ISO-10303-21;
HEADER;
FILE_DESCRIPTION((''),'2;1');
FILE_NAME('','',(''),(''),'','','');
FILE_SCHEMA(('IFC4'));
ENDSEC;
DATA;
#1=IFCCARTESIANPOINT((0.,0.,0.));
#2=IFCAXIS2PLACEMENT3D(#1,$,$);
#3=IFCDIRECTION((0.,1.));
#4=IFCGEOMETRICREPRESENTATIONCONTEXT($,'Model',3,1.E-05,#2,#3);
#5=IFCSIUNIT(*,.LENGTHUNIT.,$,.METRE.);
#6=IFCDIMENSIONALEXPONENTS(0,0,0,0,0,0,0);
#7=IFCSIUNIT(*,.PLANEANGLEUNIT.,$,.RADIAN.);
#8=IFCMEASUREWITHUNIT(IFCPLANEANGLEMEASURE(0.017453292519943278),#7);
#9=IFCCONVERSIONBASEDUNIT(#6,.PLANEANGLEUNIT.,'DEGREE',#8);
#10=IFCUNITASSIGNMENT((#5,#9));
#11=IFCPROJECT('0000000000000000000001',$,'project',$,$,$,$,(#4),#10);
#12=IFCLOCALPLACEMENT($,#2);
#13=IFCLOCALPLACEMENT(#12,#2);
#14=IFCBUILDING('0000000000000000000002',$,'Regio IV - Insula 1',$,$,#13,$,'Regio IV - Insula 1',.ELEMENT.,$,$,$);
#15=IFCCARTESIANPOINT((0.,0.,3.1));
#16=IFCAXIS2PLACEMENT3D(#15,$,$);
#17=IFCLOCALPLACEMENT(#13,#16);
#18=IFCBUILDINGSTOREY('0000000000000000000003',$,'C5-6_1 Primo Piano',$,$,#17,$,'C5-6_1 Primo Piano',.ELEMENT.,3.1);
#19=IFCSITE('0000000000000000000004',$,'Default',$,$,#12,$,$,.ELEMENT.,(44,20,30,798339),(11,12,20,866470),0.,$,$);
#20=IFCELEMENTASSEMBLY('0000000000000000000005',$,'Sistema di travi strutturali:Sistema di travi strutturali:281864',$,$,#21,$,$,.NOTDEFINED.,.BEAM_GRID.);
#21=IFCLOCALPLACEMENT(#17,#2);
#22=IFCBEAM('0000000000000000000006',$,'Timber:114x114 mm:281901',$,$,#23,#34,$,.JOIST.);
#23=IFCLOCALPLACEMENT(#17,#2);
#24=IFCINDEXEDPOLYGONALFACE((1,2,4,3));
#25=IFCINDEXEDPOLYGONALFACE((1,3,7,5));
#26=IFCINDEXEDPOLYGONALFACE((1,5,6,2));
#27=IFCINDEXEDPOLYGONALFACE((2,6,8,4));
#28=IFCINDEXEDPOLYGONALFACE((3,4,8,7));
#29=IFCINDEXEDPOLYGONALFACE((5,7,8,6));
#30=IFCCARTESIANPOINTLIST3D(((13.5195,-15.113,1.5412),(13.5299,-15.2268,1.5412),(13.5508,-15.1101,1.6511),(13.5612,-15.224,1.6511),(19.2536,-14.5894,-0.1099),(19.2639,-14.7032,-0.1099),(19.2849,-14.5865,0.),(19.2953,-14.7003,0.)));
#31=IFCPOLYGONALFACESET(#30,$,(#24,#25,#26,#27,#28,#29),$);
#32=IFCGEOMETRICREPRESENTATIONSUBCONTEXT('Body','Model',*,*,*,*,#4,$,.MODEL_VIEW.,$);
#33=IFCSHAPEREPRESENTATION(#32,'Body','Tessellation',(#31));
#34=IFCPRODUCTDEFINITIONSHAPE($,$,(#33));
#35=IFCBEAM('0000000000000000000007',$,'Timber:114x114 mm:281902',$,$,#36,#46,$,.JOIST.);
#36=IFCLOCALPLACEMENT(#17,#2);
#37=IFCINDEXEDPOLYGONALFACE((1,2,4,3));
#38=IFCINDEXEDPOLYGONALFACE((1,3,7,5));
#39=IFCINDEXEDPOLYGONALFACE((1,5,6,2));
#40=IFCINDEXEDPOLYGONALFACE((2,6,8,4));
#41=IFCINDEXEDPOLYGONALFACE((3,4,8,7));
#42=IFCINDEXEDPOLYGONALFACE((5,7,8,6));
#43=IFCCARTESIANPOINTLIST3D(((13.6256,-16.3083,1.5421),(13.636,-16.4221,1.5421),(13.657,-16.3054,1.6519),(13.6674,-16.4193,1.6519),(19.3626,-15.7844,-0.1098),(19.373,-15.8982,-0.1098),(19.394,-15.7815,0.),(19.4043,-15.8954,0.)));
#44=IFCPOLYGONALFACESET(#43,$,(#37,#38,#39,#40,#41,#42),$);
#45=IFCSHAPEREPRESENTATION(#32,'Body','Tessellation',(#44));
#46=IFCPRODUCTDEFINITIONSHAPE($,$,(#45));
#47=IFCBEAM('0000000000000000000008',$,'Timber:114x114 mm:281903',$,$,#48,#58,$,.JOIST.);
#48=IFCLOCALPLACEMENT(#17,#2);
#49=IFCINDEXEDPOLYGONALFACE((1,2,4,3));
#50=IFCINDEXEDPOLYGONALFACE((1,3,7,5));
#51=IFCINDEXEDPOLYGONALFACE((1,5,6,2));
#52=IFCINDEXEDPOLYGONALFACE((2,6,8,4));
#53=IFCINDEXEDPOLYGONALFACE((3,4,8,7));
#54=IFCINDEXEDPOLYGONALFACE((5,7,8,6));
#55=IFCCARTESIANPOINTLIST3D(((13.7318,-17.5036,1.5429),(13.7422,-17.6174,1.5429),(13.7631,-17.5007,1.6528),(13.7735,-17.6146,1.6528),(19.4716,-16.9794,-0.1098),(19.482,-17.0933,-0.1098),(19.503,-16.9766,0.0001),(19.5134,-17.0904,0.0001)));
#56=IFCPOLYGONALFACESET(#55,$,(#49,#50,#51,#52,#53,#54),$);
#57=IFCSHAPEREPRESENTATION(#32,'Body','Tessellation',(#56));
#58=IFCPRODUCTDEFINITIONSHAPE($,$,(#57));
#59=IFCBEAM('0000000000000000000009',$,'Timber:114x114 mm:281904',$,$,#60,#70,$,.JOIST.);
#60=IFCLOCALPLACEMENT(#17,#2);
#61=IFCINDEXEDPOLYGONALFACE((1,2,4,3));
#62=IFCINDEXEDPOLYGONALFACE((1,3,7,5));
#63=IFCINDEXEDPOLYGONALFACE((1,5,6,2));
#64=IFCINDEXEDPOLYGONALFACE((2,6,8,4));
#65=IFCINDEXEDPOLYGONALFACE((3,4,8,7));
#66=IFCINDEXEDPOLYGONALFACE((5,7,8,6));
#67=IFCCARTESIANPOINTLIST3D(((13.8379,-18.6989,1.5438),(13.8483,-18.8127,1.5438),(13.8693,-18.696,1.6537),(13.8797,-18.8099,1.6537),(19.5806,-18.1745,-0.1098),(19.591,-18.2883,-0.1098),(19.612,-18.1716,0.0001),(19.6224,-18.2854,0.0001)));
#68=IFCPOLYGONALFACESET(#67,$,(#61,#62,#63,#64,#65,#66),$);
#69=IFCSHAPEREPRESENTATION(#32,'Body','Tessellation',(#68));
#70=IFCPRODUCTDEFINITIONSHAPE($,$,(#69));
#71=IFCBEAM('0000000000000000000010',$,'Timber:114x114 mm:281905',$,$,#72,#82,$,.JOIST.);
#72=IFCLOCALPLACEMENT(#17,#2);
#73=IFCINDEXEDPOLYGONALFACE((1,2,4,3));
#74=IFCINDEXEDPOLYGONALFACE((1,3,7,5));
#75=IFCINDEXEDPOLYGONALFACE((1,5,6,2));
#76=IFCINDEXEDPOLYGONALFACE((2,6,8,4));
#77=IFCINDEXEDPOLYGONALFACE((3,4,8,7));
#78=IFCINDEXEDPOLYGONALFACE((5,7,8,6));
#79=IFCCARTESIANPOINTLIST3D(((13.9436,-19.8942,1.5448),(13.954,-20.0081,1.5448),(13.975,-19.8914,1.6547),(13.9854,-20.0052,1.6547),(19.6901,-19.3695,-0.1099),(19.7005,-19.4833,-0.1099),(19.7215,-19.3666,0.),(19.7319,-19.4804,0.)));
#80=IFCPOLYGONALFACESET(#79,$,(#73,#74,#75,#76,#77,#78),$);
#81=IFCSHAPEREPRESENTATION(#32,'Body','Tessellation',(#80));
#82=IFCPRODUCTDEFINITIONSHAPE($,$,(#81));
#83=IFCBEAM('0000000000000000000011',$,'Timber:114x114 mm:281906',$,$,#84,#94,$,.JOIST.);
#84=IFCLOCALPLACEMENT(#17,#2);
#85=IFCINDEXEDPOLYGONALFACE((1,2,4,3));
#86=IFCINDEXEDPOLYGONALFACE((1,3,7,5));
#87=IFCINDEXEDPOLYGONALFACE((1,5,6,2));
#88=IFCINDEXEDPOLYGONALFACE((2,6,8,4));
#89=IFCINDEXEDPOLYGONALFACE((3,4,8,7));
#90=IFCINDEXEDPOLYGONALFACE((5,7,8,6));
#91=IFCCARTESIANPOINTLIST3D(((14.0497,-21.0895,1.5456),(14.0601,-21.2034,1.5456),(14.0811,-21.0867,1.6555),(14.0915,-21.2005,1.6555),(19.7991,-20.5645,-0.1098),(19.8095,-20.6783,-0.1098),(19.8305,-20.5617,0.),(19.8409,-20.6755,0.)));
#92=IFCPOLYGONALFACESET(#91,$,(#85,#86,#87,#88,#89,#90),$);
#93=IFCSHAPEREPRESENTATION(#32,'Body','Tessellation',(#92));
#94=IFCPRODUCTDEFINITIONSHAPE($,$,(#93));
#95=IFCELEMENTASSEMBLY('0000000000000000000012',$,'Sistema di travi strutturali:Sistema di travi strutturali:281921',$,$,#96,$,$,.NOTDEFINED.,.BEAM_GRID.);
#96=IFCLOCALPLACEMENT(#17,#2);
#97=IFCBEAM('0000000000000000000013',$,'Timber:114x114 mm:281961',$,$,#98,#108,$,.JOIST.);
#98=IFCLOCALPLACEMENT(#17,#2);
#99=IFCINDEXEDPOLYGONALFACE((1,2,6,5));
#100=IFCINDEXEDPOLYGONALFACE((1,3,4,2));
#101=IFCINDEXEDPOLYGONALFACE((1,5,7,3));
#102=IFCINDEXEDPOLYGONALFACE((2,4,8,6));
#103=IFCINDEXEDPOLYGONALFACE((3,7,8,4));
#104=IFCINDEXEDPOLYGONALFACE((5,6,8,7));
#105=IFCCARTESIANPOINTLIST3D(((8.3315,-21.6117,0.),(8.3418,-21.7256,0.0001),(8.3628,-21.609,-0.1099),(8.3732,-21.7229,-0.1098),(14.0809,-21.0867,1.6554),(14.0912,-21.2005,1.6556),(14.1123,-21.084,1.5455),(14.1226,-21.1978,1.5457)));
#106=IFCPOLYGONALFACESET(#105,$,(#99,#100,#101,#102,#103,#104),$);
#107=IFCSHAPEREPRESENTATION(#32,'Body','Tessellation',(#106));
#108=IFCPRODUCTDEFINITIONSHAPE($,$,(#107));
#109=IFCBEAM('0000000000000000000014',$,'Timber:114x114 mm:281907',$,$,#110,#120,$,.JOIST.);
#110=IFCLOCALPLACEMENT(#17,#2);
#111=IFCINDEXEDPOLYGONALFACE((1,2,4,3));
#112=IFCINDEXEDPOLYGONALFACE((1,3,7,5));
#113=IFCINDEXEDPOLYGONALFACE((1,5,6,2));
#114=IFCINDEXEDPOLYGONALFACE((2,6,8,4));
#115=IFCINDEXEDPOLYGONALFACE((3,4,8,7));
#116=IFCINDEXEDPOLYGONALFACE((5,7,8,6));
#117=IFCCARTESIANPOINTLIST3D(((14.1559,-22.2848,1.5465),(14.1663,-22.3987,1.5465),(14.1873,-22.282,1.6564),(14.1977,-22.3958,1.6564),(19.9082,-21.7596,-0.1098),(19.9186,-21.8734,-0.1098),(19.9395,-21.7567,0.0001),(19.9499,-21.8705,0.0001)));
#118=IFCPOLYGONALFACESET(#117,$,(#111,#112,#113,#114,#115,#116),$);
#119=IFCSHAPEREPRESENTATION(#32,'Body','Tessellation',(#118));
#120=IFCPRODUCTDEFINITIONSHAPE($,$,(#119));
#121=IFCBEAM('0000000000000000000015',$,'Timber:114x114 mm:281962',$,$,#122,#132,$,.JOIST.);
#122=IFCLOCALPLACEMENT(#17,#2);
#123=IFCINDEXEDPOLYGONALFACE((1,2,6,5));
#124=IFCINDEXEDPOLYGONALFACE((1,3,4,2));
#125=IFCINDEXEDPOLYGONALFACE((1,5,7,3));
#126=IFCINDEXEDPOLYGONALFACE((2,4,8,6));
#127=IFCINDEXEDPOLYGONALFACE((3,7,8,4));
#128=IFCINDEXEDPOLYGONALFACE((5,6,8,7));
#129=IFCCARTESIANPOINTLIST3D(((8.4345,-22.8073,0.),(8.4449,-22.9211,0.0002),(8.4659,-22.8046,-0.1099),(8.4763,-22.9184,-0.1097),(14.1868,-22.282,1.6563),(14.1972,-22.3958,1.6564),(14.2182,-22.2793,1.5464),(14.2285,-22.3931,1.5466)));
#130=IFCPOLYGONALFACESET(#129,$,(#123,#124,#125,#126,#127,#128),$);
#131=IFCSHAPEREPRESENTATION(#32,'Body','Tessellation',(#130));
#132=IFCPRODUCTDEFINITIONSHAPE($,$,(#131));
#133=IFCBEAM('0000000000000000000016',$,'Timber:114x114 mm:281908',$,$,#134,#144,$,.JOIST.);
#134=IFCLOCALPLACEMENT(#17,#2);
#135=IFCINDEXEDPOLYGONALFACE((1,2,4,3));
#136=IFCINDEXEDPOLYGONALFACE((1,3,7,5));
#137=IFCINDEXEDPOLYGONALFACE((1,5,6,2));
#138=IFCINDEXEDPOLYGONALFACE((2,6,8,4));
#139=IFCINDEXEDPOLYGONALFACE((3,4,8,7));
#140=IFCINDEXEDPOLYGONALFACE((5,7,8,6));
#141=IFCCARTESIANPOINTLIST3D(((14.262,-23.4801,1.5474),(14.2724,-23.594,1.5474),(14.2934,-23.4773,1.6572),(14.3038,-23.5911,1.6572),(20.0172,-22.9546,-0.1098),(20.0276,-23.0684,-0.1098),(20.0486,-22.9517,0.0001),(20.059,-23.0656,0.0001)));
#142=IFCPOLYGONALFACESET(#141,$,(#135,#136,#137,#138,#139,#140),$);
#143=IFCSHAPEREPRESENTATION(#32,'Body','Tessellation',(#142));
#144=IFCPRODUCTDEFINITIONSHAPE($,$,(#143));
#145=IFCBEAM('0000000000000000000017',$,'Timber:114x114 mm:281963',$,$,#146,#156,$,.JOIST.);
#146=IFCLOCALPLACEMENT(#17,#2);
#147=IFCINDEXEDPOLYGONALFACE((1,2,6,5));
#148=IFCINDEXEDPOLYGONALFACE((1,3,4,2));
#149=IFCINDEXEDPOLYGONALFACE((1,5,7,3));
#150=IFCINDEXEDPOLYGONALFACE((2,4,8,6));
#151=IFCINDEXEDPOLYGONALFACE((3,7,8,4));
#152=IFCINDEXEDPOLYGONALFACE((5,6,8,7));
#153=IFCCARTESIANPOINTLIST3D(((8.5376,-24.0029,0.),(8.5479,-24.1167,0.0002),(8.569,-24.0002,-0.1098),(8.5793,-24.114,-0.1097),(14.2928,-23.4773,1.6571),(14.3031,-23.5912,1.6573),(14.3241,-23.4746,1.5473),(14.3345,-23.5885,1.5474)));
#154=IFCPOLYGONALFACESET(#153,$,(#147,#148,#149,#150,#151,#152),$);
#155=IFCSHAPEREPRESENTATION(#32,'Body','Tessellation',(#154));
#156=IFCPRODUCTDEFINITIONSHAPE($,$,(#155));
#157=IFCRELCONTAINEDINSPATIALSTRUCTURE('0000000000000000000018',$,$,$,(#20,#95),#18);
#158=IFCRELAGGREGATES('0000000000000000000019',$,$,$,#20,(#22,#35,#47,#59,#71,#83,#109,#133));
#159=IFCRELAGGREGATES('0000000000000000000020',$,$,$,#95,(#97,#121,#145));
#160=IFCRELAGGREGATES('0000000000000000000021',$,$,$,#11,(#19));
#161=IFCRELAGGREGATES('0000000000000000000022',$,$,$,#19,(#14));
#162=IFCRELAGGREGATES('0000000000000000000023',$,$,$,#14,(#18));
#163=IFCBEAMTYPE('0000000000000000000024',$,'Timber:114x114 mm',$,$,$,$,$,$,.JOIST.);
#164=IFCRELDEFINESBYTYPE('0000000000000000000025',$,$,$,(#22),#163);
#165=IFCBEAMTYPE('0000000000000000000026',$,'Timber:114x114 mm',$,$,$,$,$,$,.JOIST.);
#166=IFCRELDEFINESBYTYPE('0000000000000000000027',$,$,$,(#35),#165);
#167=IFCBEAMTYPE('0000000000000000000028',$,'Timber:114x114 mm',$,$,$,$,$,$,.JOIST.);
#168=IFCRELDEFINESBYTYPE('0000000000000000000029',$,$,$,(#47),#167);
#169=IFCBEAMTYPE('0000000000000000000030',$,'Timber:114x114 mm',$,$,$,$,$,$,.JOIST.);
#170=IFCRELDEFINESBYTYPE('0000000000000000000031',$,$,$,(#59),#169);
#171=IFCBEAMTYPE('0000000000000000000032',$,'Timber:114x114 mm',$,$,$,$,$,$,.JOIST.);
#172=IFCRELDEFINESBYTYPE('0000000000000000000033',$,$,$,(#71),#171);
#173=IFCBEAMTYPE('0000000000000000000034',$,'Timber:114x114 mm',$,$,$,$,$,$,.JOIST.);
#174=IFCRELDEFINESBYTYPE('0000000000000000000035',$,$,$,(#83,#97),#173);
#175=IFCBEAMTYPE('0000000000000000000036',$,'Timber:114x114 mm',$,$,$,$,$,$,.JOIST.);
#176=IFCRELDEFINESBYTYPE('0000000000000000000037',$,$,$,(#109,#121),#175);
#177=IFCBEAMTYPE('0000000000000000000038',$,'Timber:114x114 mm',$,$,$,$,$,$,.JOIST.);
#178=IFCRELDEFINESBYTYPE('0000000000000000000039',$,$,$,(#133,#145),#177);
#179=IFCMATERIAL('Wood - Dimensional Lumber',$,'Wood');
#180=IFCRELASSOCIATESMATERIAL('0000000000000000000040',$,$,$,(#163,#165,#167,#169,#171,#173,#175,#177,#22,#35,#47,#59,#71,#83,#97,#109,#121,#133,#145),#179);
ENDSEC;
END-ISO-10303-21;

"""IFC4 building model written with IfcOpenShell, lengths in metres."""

from ifc_helpers import new_model, entity, si_unit, converted_unit, direction, frame, origin, origin_2d_with_axis, place, context, subcontext, project, spatial, rectangle, extrude, source, transform, mapped, material, material_profile, profile_set, profile_usage, type_object, type_shapes, element, aggregate, save


model = new_model("IFC4")

# Units and contexts
model_context = context("Model", 3, precision=1e-05, world=origin(), true_north=direction((0.0, 1.0)))
body_context = subcontext(model_context, "Body", "Model", "MODEL_VIEW")
ifc_project = project(units=[si_unit("LENGTHUNIT", "METRE"), converted_unit("PLANEANGLEUNIT", "DEGREE", entity("IfcPlaneAngleMeasure", 0.017453292519943278), si_unit("PLANEANGLEUNIT", "RADIAN"), dimensions=[0, 0, 0, 0, 0, 0, 0])], contexts=[model_context])

# Site, building, storey
site_placement = place(None, origin())
site = spatial("IfcSite", under=ifc_project, at=site_placement, Name="Default", CompositionType="ELEMENT", RefLatitude=(44, 20, 30, 798339), RefLongitude=(11, 12, 20, 866470), RefElevation=0.0)
building_placement = place(site_placement, origin())
building = spatial("IfcBuilding", under=site, at=building_placement, Name="Regio IV - Insula 1", LongName="Regio IV - Insula 1", CompositionType="ELEMENT")
storey_placement = place(building_placement, frame((0.0, 0.0, 3.1)))
storey = spatial("IfcBuildingStorey", under=building, at=storey_placement, Name="C5-6_1 Primo Piano", LongName="C5-6_1 Primo Piano", CompositionType="ELEMENT", Elevation=3.1)

# Element assembly, beams
assembly_1_placement = place(storey_placement, origin())
assembly_1 = element("IfcElementAssembly", 1, at=assembly_1_placement, inside=storey, Name="Sistema di travi strutturali:Sistema di travi strutturali:281864", AssemblyPlace="NOTDEFINED", PredefinedType="BEAM_GRID")
ifc_material = material(Name="Wood - Dimensional Lumber", Category="Wood")
ifc_material_profile_1 = material_profile(ifc_material, rectangle(XDim=5.294, YDim=0.1143, at=origin_2d_with_axis()), Name="114x114 mm")
ifc_profile_set_1 = profile_set([ifc_material_profile_1], Name="114x114 mm")
ifc_profile_usage_1 = profile_usage(ifc_profile_set_1, cardinal=8)
beam_type_1 = type_object("IfcBeamType", Name="Timber:114x114 mm", PredefinedType="JOIST", material=ifc_profile_set_1)
shared_shape_1 = source(origin(), body_context, "Body", "SweptSolid", [
    extrude(rectangle(XDim=5.99, YDim=0.1143, at=origin_2d_with_axis()), frame((0.0, 0.0, -0.0572), z_axis=(0.0, 0.0, 1.0), x_axis=(-1.0, 0.0, 0.0)), (0.0, 0.0, 1.0), 0.1143),
])
type_shapes(beam_type_1, [shared_shape_1])
beam_1_placement = place(assembly_1_placement, frame((16.4074, -14.9067, 0.7706), z_axis=(0.274495, 0.025067, 0.961262), x_axis=(-0.957279, -0.087418, 0.275637)))
beam_1 = element("IfcBeam", 2, at=beam_1_placement, type_object=beam_type_1, material=ifc_profile_usage_1, Name="Timber:114x114 mm:281901", PredefinedType="JOIST", context=body_context, shape_type="MappedRepresentation", body=[
    mapped(shared_shape_1, transform((0.0, 0.0, 0.0), scale=1.0)),
])
beam_type_2 = type_object("IfcBeamType", Name="Timber:114x114 mm", PredefinedType="JOIST", material=ifc_profile_set_1)
shared_shape_2 = source(origin(), body_context, "Body", "SweptSolid", [
    extrude(rectangle(XDim=5.993, YDim=0.1143, at=origin_2d_with_axis()), frame((0.0, 0.0, -0.0572), z_axis=(0.0, 0.0, 1.0), x_axis=(-1.0, 0.0, 0.0)), (0.0, 0.0, 1.0), 0.1143),
])
type_shapes(beam_type_2, [shared_shape_2])
beam_2_placement = place(assembly_1_placement, frame((16.515, -16.1018, 0.7711), z_axis=(0.274495, 0.025067, 0.961262), x_axis=(-0.957279, -0.087418, 0.275637)))
beam_2 = element("IfcBeam", 3, at=beam_2_placement, type_object=beam_type_2, material=ifc_profile_usage_1, Name="Timber:114x114 mm:281902", PredefinedType="JOIST", context=body_context, shape_type="MappedRepresentation", body=[
    mapped(shared_shape_2, transform((0.0, 0.0, 0.0), scale=1.0)),
])
beam_type_3 = type_object("IfcBeamType", Name="Timber:114x114 mm", PredefinedType="JOIST", material=ifc_profile_set_1)
shared_shape_3 = source(origin(), body_context, "Body", "SweptSolid", [
    extrude(rectangle(XDim=5.996, YDim=0.1143, at=origin_2d_with_axis()), frame((0.0, 0.0, -0.0572), z_axis=(0.0, 0.0, 1.0), x_axis=(-1.0, 0.0, 0.0)), (0.0, 0.0, 1.0), 0.1143),
])
type_shapes(beam_type_3, [shared_shape_3])
beam_3_placement = place(assembly_1_placement, frame((16.6226, -17.297, 0.7715), z_axis=(0.274495, 0.025067, 0.961262), x_axis=(-0.957279, -0.087418, 0.275637)))
beam_3 = element("IfcBeam", 4, at=beam_3_placement, type_object=beam_type_3, material=ifc_profile_usage_1, Name="Timber:114x114 mm:281903", PredefinedType="JOIST", context=body_context, shape_type="MappedRepresentation", body=[
    mapped(shared_shape_3, transform((0.0, 0.0, 0.0), scale=1.0)),
])
beam_type_4 = type_object("IfcBeamType", Name="Timber:114x114 mm", PredefinedType="JOIST", material=ifc_profile_set_1)
shared_shape_4 = source(origin(), body_context, "Body", "SweptSolid", [
    extrude(rectangle(XDim=5.999, YDim=0.1143, at=origin_2d_with_axis()), frame((0.0, 0.0, -0.0572), z_axis=(0.0, 0.0, 1.0), x_axis=(-1.0, 0.0, 0.0)), (0.0, 0.0, 1.0), 0.1143),
])
type_shapes(beam_type_4, [shared_shape_4])
beam_4_placement = place(assembly_1_placement, frame((16.7302, -18.4922, 0.7719), z_axis=(0.274495, 0.025067, 0.961262), x_axis=(-0.957279, -0.087418, 0.275637)))
beam_4 = element("IfcBeam", 5, at=beam_4_placement, type_object=beam_type_4, material=ifc_profile_usage_1, Name="Timber:114x114 mm:281904", PredefinedType="JOIST", context=body_context, shape_type="MappedRepresentation", body=[
    mapped(shared_shape_4, transform((0.0, 0.0, 0.0), scale=1.0)),
])
beam_type_5 = type_object("IfcBeamType", Name="Timber:114x114 mm", PredefinedType="JOIST", material=ifc_profile_set_1)
shared_shape_5 = source(origin(), body_context, "Body", "SweptSolid", [
    extrude(rectangle(XDim=6.003, YDim=0.1143, at=origin_2d_with_axis()), frame((0.0, 0.0, -0.0572), z_axis=(0.0, 0.0, 1.0), x_axis=(-1.0, 0.0, 0.0)), (0.0, 0.0, 1.0), 0.1143),
])
type_shapes(beam_type_5, [shared_shape_5])
beam_5_placement = place(assembly_1_placement, frame((16.8377, -19.6873, 0.7724), z_axis=(0.274495, 0.025067, 0.961262), x_axis=(-0.957279, -0.087418, 0.275637)))
beam_5 = element("IfcBeam", 6, at=beam_5_placement, type_object=beam_type_5, material=ifc_profile_usage_1, Name="Timber:114x114 mm:281905", PredefinedType="JOIST", context=body_context, shape_type="MappedRepresentation", body=[
    mapped(shared_shape_5, transform((0.0, 0.0, 0.0), scale=1.0)),
])
beam_type_6 = type_object("IfcBeamType", Name="Timber:114x114 mm", PredefinedType="JOIST", material=ifc_profile_set_1)
shared_shape_6 = source(origin(), body_context, "Body", "SweptSolid", [
    extrude(rectangle(XDim=6.006, YDim=0.1143, at=origin_2d_with_axis()), frame((0.0, 0.0, -0.0572), z_axis=(0.0, 0.0, 1.0), x_axis=(-1.0, 0.0, 0.0)), (0.0, 0.0, 1.0), 0.1143),
])
type_shapes(beam_type_6, [shared_shape_6])
beam_6_placement = place(assembly_1_placement, frame((16.9453, -20.8825, 0.7728), z_axis=(0.274495, 0.025067, 0.961262), x_axis=(-0.957279, -0.087418, 0.275637)))
beam_6 = element("IfcBeam", 7, at=beam_6_placement, type_object=beam_type_6, material=ifc_profile_usage_1, Name="Timber:114x114 mm:281906", PredefinedType="JOIST", context=body_context, shape_type="MappedRepresentation", body=[
    mapped(shared_shape_6, transform((0.0, 0.0, 0.0), scale=1.0)),
])

# Element assembly, beam
assembly_2_placement = place(storey_placement, origin())
assembly_2 = element("IfcElementAssembly", 8, at=assembly_2_placement, inside=storey, Name="Sistema di travi strutturali:Sistema di travi strutturali:281921", AssemblyPlace="NOTDEFINED", PredefinedType="BEAM_GRID")
beam_7_placement = place(assembly_2_placement, frame((11.227, -21.4048, 0.7728), z_axis=(-0.274621, -0.02365, 0.961262), x_axis=(-0.957279, -0.087418, -0.275634)))
beam_7 = element("IfcBeam", 9, at=beam_7_placement, type_object=beam_type_6, material=ifc_profile_usage_1, Name="Timber:114x114 mm:281961", PredefinedType="JOIST", context=body_context, shape_type="MappedRepresentation", body=[
    mapped(shared_shape_6, transform((0.0, 0.0, 0.0), scale=1.0)),
])

# Beams
beam_type_7 = type_object("IfcBeamType", Name="Timber:114x114 mm", PredefinedType="JOIST", material=ifc_profile_set_1)
shared_shape_7 = source(origin(), body_context, "Body", "SweptSolid", [
    extrude(rectangle(XDim=6.009, YDim=0.1143, at=origin_2d_with_axis()), frame((0.0, 0.0, -0.0572), z_axis=(0.0, 0.0, 1.0), x_axis=(-1.0, 0.0, 0.0)), (0.0, 0.0, 1.0), 0.1143),
])
type_shapes(beam_type_7, [shared_shape_7])
beam_8_placement = place(assembly_1_placement, frame((17.0529, -22.0777, 0.7733), z_axis=(0.274495, 0.025067, 0.961262), x_axis=(-0.957279, -0.087418, 0.275637)))
beam_8 = element("IfcBeam", 10, at=beam_8_placement, type_object=beam_type_7, material=ifc_profile_usage_1, Name="Timber:114x114 mm:281907", PredefinedType="JOIST", context=body_context, shape_type="MappedRepresentation", body=[
    mapped(shared_shape_7, transform((0.0, 0.0, 0.0), scale=1.0)),
])
beam_9_placement = place(assembly_2_placement, frame((11.3315, -22.6002, 0.7733), z_axis=(-0.274621, -0.02365, 0.961262), x_axis=(-0.957279, -0.087418, -0.275634)))
beam_9 = element("IfcBeam", 11, at=beam_9_placement, type_object=beam_type_7, material=ifc_profile_usage_1, Name="Timber:114x114 mm:281962", PredefinedType="JOIST", context=body_context, shape_type="MappedRepresentation", body=[
    mapped(shared_shape_7, transform((0.0, 0.0, 0.0), scale=1.0)),
])
beam_type_8 = type_object("IfcBeamType", Name="Timber:114x114 mm", PredefinedType="JOIST", material=ifc_profile_set_1)
shared_shape_8 = source(origin(), body_context, "Body", "SweptSolid", [
    extrude(rectangle(XDim=6.012, YDim=0.1143, at=origin_2d_with_axis()), frame((0.0, 0.0, -0.0572), z_axis=(0.0, 0.0, 1.0), x_axis=(-1.0, 0.0, 0.0)), (0.0, 0.0, 1.0), 0.1143),
])
type_shapes(beam_type_8, [shared_shape_8])
beam_10_placement = place(assembly_1_placement, frame((17.1605, -23.2728, 0.7737), z_axis=(0.274495, 0.025067, 0.961262), x_axis=(-0.957279, -0.087418, 0.275637)))
beam_10 = element("IfcBeam", 12, at=beam_10_placement, type_object=beam_type_8, material=ifc_profile_usage_1, Name="Timber:114x114 mm:281908", PredefinedType="JOIST", context=body_context, shape_type="MappedRepresentation", body=[
    mapped(shared_shape_8, transform((0.0, 0.0, 0.0), scale=1.0)),
])
aggregate(assembly_1, [beam_1, beam_2, beam_3, beam_4, beam_5, beam_6, beam_8, beam_10])
beam_11_placement = place(assembly_2_placement, frame((11.436, -23.7957, 0.7737), z_axis=(-0.274621, -0.02365, 0.961262), x_axis=(-0.957279, -0.087418, -0.275634)))
beam_11 = element("IfcBeam", 13, at=beam_11_placement, type_object=beam_type_8, material=ifc_profile_usage_1, Name="Timber:114x114 mm:281963", PredefinedType="JOIST", context=body_context, shape_type="MappedRepresentation", body=[
    mapped(shared_shape_8, transform((0.0, 0.0, 0.0), scale=1.0)),
])
aggregate(assembly_2, [beam_7, beam_9, beam_11])

save(model, "model.ifc")
